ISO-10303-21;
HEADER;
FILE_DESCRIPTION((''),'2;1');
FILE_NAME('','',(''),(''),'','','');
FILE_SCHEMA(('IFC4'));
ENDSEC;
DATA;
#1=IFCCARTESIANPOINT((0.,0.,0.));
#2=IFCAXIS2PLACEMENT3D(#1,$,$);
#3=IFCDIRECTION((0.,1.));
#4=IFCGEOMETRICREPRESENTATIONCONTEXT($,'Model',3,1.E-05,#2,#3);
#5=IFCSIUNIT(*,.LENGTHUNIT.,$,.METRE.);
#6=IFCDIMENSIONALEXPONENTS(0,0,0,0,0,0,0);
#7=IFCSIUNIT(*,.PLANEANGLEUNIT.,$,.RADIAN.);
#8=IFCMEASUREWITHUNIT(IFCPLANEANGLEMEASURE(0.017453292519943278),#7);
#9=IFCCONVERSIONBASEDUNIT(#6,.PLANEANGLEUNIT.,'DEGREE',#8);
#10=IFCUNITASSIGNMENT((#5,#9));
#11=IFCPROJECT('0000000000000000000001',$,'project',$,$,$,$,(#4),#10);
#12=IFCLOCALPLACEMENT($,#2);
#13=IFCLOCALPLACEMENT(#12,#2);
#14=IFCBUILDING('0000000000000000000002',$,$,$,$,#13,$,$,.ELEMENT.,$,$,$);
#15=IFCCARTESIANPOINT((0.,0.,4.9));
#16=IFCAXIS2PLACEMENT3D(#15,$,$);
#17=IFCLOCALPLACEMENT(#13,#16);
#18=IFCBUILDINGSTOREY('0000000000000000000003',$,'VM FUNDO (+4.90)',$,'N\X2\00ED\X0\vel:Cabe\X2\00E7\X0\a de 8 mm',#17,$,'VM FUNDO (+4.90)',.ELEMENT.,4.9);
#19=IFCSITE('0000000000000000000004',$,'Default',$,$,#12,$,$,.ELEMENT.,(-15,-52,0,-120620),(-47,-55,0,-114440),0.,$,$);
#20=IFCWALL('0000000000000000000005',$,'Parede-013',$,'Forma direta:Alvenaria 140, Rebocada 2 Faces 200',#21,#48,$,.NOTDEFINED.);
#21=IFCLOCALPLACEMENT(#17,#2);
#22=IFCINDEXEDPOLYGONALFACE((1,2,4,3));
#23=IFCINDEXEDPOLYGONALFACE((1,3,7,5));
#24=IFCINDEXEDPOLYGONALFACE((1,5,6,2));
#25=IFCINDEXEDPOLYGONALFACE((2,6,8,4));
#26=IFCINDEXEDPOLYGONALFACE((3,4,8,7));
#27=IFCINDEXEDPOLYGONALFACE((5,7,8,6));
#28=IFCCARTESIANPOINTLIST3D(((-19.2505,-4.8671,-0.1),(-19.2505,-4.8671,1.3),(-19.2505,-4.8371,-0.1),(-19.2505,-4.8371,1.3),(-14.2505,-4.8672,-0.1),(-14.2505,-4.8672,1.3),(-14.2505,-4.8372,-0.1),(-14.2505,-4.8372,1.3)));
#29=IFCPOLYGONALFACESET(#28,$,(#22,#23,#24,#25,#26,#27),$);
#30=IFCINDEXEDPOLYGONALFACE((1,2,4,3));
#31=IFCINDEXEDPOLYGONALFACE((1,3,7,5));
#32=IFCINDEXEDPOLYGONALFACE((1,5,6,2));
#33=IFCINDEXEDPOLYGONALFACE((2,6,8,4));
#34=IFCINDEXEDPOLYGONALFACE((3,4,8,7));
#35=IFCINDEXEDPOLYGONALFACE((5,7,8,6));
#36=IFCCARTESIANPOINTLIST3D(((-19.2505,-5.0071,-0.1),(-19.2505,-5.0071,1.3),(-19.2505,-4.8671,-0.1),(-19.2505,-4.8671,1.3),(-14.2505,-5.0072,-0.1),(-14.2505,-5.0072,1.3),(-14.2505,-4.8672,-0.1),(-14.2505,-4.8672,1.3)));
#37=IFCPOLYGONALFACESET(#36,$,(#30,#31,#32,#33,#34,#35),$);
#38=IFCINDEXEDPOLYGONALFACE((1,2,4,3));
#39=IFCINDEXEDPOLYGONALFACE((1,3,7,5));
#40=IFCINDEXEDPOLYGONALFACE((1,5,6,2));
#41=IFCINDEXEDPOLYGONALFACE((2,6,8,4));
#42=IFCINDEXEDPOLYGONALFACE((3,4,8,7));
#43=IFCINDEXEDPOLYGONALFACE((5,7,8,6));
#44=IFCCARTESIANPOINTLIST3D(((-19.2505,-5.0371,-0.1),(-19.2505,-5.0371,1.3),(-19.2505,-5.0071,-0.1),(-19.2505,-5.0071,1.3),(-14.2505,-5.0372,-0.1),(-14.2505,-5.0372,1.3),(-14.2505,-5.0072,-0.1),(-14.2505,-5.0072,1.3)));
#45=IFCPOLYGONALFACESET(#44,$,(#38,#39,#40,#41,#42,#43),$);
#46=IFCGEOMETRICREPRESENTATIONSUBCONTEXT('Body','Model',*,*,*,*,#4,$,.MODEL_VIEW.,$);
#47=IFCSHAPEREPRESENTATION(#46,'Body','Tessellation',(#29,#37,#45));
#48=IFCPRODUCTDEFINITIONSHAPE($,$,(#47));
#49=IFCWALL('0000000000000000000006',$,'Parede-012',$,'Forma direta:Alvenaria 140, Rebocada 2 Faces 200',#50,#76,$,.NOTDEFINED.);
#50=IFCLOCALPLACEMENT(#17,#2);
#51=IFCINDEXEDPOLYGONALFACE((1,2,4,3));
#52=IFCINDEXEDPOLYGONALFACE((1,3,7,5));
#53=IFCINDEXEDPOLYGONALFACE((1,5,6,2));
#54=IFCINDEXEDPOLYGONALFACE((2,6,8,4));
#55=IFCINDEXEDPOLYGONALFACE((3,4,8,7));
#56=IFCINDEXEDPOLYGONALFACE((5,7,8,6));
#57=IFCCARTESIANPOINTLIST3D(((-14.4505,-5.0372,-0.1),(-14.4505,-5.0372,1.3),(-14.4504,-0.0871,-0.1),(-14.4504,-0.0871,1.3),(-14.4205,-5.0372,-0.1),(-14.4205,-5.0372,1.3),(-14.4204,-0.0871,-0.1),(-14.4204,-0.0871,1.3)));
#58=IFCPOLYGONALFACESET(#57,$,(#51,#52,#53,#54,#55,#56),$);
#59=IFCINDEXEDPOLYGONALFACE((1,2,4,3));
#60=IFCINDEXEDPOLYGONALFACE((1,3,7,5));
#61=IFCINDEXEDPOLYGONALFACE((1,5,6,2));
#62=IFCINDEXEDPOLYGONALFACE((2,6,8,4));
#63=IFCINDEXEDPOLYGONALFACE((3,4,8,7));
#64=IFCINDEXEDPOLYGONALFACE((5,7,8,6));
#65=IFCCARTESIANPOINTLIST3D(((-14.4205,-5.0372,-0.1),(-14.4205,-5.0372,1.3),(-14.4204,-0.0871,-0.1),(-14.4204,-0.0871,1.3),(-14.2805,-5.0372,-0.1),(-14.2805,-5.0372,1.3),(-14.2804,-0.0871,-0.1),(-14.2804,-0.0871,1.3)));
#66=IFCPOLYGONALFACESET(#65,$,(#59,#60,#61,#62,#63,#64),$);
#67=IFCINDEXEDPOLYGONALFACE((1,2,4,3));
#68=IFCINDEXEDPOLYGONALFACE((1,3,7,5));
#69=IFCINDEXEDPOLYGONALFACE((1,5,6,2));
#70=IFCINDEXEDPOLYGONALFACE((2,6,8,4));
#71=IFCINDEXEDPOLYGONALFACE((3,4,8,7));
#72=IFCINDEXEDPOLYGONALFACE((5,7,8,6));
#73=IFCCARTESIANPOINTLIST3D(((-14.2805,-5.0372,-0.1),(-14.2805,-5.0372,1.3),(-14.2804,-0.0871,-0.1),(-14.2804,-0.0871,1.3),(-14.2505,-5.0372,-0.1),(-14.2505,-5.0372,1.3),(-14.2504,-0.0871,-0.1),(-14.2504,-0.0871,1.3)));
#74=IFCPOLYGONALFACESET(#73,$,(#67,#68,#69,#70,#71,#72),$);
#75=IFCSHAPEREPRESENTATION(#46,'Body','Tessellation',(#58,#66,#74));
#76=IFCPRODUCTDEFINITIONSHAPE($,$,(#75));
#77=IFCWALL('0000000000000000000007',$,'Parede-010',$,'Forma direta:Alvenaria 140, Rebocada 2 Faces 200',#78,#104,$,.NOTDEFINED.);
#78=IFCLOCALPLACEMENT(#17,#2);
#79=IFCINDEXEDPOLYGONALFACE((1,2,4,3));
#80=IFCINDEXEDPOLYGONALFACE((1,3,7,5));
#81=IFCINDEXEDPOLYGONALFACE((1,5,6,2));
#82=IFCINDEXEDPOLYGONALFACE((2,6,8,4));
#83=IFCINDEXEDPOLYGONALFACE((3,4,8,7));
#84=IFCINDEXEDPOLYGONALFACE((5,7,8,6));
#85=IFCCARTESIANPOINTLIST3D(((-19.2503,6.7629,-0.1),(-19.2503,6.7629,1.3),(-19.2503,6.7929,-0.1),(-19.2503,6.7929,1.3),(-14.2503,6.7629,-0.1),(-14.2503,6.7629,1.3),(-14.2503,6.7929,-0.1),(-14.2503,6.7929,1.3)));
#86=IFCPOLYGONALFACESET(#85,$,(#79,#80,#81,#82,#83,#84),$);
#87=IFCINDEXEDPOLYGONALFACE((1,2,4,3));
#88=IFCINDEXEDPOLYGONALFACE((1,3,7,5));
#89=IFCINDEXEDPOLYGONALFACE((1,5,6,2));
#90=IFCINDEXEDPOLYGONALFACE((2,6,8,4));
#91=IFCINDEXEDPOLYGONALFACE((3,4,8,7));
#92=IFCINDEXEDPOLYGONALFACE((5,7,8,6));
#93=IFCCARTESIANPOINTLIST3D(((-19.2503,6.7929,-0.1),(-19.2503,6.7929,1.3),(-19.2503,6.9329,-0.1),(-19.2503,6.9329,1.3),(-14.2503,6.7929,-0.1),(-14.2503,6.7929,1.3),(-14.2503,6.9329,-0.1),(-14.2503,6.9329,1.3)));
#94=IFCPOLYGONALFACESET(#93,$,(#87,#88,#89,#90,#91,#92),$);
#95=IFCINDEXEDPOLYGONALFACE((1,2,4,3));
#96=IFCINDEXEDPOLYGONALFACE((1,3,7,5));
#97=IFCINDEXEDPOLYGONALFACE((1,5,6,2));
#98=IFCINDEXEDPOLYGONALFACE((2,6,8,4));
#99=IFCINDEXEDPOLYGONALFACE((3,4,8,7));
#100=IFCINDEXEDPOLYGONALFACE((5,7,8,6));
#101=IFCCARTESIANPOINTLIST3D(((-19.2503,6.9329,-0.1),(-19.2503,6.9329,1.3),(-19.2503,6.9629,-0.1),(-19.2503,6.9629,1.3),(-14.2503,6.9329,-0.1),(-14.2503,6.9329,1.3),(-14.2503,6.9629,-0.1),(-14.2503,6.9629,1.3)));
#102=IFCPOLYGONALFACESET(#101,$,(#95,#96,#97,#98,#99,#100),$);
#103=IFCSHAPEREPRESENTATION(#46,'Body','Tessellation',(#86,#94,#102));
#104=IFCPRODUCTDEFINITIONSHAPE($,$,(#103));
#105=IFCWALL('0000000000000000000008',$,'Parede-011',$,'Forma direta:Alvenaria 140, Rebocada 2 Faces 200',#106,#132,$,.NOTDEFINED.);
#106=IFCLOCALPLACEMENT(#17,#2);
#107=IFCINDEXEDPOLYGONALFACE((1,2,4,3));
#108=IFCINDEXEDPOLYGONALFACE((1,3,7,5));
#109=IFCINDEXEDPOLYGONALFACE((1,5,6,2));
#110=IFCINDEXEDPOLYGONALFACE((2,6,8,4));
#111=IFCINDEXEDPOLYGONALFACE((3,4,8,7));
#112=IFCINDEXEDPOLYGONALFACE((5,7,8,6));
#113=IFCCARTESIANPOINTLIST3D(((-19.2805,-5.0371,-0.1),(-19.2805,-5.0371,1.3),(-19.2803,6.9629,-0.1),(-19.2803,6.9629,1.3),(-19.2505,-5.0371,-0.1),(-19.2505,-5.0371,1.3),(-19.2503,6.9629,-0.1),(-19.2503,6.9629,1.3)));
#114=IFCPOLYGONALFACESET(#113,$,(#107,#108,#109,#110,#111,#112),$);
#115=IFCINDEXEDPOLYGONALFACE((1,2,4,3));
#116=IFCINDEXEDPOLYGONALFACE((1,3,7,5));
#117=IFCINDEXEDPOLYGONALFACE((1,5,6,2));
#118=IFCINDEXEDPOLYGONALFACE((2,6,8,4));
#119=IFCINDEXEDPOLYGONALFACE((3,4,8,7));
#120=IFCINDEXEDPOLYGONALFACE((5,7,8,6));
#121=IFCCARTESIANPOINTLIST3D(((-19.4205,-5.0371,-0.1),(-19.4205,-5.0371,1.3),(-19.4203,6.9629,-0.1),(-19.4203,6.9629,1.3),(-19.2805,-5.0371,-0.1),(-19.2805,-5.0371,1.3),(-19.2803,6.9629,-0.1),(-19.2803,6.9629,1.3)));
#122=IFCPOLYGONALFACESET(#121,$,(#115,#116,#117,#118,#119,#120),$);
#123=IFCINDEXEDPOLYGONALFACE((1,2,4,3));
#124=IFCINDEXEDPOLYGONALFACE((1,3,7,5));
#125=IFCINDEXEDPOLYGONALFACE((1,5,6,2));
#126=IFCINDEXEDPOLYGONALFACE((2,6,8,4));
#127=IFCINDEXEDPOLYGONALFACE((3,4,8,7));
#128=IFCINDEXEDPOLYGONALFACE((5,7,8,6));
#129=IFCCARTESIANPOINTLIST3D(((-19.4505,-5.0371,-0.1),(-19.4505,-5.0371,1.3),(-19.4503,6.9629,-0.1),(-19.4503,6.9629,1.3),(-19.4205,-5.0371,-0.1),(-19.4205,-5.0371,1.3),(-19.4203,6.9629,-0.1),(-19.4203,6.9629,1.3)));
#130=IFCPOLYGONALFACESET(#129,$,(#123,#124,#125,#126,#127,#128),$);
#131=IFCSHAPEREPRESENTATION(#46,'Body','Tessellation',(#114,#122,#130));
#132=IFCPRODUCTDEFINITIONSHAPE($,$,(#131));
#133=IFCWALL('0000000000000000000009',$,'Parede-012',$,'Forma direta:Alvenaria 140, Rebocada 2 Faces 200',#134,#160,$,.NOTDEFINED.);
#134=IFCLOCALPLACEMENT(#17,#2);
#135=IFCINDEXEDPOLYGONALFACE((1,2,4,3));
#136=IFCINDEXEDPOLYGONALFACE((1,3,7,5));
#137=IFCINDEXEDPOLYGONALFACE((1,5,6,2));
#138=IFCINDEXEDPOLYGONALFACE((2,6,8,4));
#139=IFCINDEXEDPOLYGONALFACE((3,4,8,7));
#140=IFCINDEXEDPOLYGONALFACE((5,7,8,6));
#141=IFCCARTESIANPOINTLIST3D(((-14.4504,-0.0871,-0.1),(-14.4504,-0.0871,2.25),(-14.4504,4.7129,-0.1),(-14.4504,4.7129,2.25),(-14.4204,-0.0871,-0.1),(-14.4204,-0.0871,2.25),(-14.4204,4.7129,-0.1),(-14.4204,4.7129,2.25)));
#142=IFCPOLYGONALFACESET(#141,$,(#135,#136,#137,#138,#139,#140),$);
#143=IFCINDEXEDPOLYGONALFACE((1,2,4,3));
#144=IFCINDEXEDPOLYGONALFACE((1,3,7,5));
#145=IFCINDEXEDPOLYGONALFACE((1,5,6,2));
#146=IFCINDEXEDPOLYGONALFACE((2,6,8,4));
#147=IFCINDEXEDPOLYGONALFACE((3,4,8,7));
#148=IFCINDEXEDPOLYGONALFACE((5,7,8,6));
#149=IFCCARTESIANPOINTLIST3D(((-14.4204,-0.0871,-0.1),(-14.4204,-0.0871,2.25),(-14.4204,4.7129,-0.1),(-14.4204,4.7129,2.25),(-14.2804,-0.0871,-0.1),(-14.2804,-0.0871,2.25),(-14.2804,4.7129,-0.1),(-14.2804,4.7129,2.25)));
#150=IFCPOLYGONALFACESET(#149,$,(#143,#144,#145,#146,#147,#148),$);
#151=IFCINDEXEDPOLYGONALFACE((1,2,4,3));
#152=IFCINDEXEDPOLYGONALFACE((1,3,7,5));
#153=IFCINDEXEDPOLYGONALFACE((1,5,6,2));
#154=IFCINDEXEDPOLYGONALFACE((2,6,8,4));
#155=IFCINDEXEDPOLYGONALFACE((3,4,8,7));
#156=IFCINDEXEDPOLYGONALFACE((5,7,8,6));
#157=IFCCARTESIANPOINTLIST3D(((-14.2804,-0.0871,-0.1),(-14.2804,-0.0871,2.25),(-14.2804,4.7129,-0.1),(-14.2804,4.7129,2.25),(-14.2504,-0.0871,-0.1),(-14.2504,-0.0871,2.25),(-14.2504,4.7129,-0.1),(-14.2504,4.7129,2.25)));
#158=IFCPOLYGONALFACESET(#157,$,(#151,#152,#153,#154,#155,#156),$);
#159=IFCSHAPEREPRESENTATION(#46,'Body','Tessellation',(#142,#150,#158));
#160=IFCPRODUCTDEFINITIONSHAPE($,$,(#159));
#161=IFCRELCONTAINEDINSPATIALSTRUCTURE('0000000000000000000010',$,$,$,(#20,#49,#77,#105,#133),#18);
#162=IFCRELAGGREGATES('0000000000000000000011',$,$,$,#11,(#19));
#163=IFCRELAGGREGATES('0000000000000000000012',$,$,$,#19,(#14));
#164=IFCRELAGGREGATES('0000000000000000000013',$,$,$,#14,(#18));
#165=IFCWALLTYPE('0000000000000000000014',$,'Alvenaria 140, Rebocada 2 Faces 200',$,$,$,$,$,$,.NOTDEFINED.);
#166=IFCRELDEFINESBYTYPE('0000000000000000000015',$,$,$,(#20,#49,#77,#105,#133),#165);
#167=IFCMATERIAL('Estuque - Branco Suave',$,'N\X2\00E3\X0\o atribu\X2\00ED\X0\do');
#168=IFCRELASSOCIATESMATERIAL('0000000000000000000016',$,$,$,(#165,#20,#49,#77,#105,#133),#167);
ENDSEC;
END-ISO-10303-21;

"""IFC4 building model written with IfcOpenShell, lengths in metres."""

from ifc_helpers import new_model, entity, si_unit, converted_unit, direction, frame, origin, place, context, subcontext, project, spatial, indexed_curve, outline, extrude, material, type_object, element, save


model = new_model("IFC4")

# Units and contexts
model_context = context("Model", 3, precision=1e-05, world=origin(), true_north=direction((0.0, 1.0)))
body_context = subcontext(model_context, "Body", "Model", "MODEL_VIEW")
ifc_project = project(units=[si_unit("LENGTHUNIT", "METRE"), converted_unit("PLANEANGLEUNIT", "DEGREE", entity("IfcPlaneAngleMeasure", 0.017453292519943278), si_unit("PLANEANGLEUNIT", "RADIAN"), dimensions=[0, 0, 0, 0, 0, 0, 0])], contexts=[model_context])

# Site, building, storey
site_placement = place(None, origin())
site = spatial("IfcSite", under=ifc_project, at=site_placement, Name="Default", CompositionType="ELEMENT", RefLatitude=(-15, -52, 0, -120620), RefLongitude=(-47, -55, 0, -114440), RefElevation=0.0)
building_placement = place(site_placement, origin())
building = spatial("IfcBuilding", under=site, at=building_placement, CompositionType="ELEMENT")
storey_placement = place(building_placement, frame((0.0, 0.0, 4.9)))
storey = spatial("IfcBuildingStorey", under=building, at=storey_placement, Name="VM FUNDO (+4.90)", ObjectType="Nível:Cabeça de 8 mm", LongName="VM FUNDO (+4.90)", CompositionType="ELEMENT", Elevation=4.9)

# Walls
ifc_material = material(Name="Estuque - Branco Suave", Category="Não atribuído")
wall_type = type_object("IfcWallType", Name="Alvenaria 140, Rebocada 2 Faces 200", PredefinedType="NOTDEFINED", material=ifc_material)
wall_1_placement = place(storey_placement, frame((-19.2505, -5.0372, -0.1)))
element("IfcWall", 1, at=wall_1_placement, inside=storey, type_object=wall_type, material=ifc_material, Name="Parede-013", ObjectType="Forma direta:Alvenaria 140, Rebocada 2 Faces 200", PredefinedType="NOTDEFINED", context=body_context, shape_type="SweptSolid", body=[
    extrude(outline(indexed_curve([(-0.015, -2.5), (0.015, -2.5), (0.015, 2.5), (-0.015, 2.5), (-0.015, -2.5)], self_intersect=False)), frame((2.5, 0.185, 0.0), z_axis=(0.0, 0.0, 1.0), x_axis=(0.000013, 1.0, 0.0)), (0.0, 0.0, 1.0), 1.4),
    extrude(outline(indexed_curve([(-0.07, -2.5), (0.07, -2.5), (0.07, 2.5), (-0.07, 2.5), (-0.07, -2.5)], self_intersect=False)), frame((2.5, 0.1, 0.0), z_axis=(0.0, 0.0, 1.0), x_axis=(-0.000013, -1.0, 0.0)), (0.0, 0.0, 1.0), 1.4),
    extrude(outline(indexed_curve([(-0.015, -2.5), (0.015, -2.5), (0.015, 2.5), (-0.015, 2.5), (-0.015, -2.5)], self_intersect=False)), frame((2.5, 0.015, 0.0), z_axis=(0.0, 0.0, 1.0), x_axis=(-0.000013, -1.0, 0.0)), (0.0, 0.0, 1.0), 1.4),
])
wall_2_placement = place(storey_placement, frame((-14.4505, -5.0372, -0.1), z_axis=(0.0, 0.0, 1.0), x_axis=(0.0, 1.0, 0.0)))
element("IfcWall", 2, at=wall_2_placement, inside=storey, type_object=wall_type, material=ifc_material, Name="Parede-012", ObjectType="Forma direta:Alvenaria 140, Rebocada 2 Faces 200", PredefinedType="NOTDEFINED", context=body_context, shape_type="SweptSolid", body=[
    extrude(outline(indexed_curve([(-0.015, -2.475), (0.015, -2.475), (0.015, 2.475), (-0.015, 2.475), (-0.015, -2.475)], self_intersect=False)), frame((2.475, -0.015, 0.0), z_axis=(0.0, 0.0, 1.0), x_axis=(0.000013, 1.0, 0.0)), (0.0, 0.0, 1.0), 1.4),
    extrude(outline(indexed_curve([(-0.07, -2.475), (0.07, -2.475), (0.07, 2.475), (-0.07, 2.475), (-0.07, -2.475)], self_intersect=False)), frame((2.475, -0.1, 0.0), z_axis=(0.0, 0.0, 1.0), x_axis=(-0.000013, -1.0, 0.0)), (0.0, 0.0, 1.0), 1.4),
    extrude(outline(indexed_curve([(-0.015, -2.475), (0.015, -2.475), (0.015, 2.475), (-0.015, 2.475), (-0.015, -2.475)], self_intersect=False)), frame((2.475, -0.185, 0.0), z_axis=(0.0, 0.0, 1.0), x_axis=(-0.000013, -1.0, 0.0)), (0.0, 0.0, 1.0), 1.4),
])
wall_3_placement = place(storey_placement, frame((-19.2503, 6.7629, -0.1)))
element("IfcWall", 3, at=wall_3_placement, inside=storey, type_object=wall_type, material=ifc_material, Name="Parede-010", ObjectType="Forma direta:Alvenaria 140, Rebocada 2 Faces 200", PredefinedType="NOTDEFINED", context=body_context, shape_type="SweptSolid", body=[
    extrude(outline(indexed_curve([(-0.015, -2.5), (0.015, -2.5), (0.015, 2.5), (-0.015, 2.5), (-0.015, -2.5)], self_intersect=False)), frame((2.5, 0.015, 0.0), z_axis=(0.0, 0.0, 1.0), x_axis=(-0.00001, -1.0, 0.0)), (0.0, 0.0, 1.0), 1.4),
    extrude(outline(indexed_curve([(-0.07, -2.5), (0.07, -2.5), (0.07, 2.5), (-0.07, 2.5), (-0.07, -2.5)], self_intersect=False)), frame((2.5, 0.1, 0.0), z_axis=(0.0, 0.0, 1.0), x_axis=(0.00001, 1.0, 0.0)), (0.0, 0.0, 1.0), 1.4),
    extrude(outline(indexed_curve([(-0.015, -2.5), (0.015, -2.5), (0.015, 2.5), (-0.015, 2.5), (-0.015, -2.5)], self_intersect=False)), frame((2.5, 0.185, 0.0), z_axis=(0.0, 0.0, 1.0), x_axis=(0.00001, 1.0, 0.0)), (0.0, 0.0, 1.0), 1.4),
])
wall_4_placement = place(storey_placement, frame((-19.4505, -5.0371, -0.1), z_axis=(0.0, 0.0, 1.0), x_axis=(0.0, 1.0, 0.0)))
element("IfcWall", 4, at=wall_4_placement, inside=storey, type_object=wall_type, material=ifc_material, Name="Parede-011", ObjectType="Forma direta:Alvenaria 140, Rebocada 2 Faces 200", PredefinedType="NOTDEFINED", context=body_context, shape_type="SweptSolid", body=[
    extrude(outline(indexed_curve([(-0.015, -6.0), (0.015, -6.0), (0.015, 6.0), (-0.015, 6.0), (-0.015, -6.0)], self_intersect=False)), frame((6.0, -0.1851, 0.0), z_axis=(0.0, 0.0, 1.0), x_axis=(-0.000013, -1.0, 0.0)), (0.0, 0.0, 1.0), 1.4),
    extrude(outline(indexed_curve([(-0.07, -6.0), (0.07, -6.0), (0.07, 6.0), (-0.07, 6.0), (-0.07, -6.0)], self_intersect=False)), frame((6.0, -0.1001, 0.0), z_axis=(0.0, 0.0, 1.0), x_axis=(0.000013, 1.0, 0.0)), (0.0, 0.0, 1.0), 1.4),
    extrude(outline(indexed_curve([(-0.015, -6.0), (0.015, -6.0), (0.015, 6.0), (-0.015, 6.0), (-0.015, -6.0)], self_intersect=False)), frame((6.0, -0.0151, 0.0), z_axis=(0.0, 0.0, 1.0), x_axis=(0.000013, 1.0, 0.0)), (0.0, 0.0, 1.0), 1.4),
])
wall_5_placement = place(storey_placement, frame((-14.4504, -0.0871, -0.1), z_axis=(0.0, 0.0, 1.0), x_axis=(0.0, 1.0, 0.0)))
element("IfcWall", 5, at=wall_5_placement, inside=storey, type_object=wall_type, material=ifc_material, Name="Parede-012", ObjectType="Forma direta:Alvenaria 140, Rebocada 2 Faces 200", PredefinedType="NOTDEFINED", context=body_context, shape_type="SweptSolid", body=[
    extrude(outline(indexed_curve([(-0.015, -2.4), (0.015, -2.4), (0.015, 2.4), (-0.015, 2.4), (-0.015, -2.4)], self_intersect=False)), frame((2.4, -0.015, 0.0), z_axis=(0.0, 0.0, 1.0), x_axis=(0.000013, 1.0, 0.0)), (0.0, 0.0, 1.0), 2.35),
    extrude(outline(indexed_curve([(-0.07, -2.4), (0.07, -2.4), (0.07, 2.4), (-0.07, 2.4), (-0.07, -2.4)], self_intersect=False)), frame((2.4, -0.1, 0.0), z_axis=(0.0, 0.0, 1.0), x_axis=(-0.000013, -1.0, 0.0)), (0.0, 0.0, 1.0), 2.35),
    extrude(outline(indexed_curve([(-0.015, -2.4), (0.015, -2.4), (0.015, 2.4), (-0.015, 2.4), (-0.015, -2.4)], self_intersect=False)), frame((2.4, -0.185, 0.0), z_axis=(0.0, 0.0, 1.0), x_axis=(-0.000013, -1.0, 0.0)), (0.0, 0.0, 1.0), 2.35),
])

save(model, "model.ifc")
